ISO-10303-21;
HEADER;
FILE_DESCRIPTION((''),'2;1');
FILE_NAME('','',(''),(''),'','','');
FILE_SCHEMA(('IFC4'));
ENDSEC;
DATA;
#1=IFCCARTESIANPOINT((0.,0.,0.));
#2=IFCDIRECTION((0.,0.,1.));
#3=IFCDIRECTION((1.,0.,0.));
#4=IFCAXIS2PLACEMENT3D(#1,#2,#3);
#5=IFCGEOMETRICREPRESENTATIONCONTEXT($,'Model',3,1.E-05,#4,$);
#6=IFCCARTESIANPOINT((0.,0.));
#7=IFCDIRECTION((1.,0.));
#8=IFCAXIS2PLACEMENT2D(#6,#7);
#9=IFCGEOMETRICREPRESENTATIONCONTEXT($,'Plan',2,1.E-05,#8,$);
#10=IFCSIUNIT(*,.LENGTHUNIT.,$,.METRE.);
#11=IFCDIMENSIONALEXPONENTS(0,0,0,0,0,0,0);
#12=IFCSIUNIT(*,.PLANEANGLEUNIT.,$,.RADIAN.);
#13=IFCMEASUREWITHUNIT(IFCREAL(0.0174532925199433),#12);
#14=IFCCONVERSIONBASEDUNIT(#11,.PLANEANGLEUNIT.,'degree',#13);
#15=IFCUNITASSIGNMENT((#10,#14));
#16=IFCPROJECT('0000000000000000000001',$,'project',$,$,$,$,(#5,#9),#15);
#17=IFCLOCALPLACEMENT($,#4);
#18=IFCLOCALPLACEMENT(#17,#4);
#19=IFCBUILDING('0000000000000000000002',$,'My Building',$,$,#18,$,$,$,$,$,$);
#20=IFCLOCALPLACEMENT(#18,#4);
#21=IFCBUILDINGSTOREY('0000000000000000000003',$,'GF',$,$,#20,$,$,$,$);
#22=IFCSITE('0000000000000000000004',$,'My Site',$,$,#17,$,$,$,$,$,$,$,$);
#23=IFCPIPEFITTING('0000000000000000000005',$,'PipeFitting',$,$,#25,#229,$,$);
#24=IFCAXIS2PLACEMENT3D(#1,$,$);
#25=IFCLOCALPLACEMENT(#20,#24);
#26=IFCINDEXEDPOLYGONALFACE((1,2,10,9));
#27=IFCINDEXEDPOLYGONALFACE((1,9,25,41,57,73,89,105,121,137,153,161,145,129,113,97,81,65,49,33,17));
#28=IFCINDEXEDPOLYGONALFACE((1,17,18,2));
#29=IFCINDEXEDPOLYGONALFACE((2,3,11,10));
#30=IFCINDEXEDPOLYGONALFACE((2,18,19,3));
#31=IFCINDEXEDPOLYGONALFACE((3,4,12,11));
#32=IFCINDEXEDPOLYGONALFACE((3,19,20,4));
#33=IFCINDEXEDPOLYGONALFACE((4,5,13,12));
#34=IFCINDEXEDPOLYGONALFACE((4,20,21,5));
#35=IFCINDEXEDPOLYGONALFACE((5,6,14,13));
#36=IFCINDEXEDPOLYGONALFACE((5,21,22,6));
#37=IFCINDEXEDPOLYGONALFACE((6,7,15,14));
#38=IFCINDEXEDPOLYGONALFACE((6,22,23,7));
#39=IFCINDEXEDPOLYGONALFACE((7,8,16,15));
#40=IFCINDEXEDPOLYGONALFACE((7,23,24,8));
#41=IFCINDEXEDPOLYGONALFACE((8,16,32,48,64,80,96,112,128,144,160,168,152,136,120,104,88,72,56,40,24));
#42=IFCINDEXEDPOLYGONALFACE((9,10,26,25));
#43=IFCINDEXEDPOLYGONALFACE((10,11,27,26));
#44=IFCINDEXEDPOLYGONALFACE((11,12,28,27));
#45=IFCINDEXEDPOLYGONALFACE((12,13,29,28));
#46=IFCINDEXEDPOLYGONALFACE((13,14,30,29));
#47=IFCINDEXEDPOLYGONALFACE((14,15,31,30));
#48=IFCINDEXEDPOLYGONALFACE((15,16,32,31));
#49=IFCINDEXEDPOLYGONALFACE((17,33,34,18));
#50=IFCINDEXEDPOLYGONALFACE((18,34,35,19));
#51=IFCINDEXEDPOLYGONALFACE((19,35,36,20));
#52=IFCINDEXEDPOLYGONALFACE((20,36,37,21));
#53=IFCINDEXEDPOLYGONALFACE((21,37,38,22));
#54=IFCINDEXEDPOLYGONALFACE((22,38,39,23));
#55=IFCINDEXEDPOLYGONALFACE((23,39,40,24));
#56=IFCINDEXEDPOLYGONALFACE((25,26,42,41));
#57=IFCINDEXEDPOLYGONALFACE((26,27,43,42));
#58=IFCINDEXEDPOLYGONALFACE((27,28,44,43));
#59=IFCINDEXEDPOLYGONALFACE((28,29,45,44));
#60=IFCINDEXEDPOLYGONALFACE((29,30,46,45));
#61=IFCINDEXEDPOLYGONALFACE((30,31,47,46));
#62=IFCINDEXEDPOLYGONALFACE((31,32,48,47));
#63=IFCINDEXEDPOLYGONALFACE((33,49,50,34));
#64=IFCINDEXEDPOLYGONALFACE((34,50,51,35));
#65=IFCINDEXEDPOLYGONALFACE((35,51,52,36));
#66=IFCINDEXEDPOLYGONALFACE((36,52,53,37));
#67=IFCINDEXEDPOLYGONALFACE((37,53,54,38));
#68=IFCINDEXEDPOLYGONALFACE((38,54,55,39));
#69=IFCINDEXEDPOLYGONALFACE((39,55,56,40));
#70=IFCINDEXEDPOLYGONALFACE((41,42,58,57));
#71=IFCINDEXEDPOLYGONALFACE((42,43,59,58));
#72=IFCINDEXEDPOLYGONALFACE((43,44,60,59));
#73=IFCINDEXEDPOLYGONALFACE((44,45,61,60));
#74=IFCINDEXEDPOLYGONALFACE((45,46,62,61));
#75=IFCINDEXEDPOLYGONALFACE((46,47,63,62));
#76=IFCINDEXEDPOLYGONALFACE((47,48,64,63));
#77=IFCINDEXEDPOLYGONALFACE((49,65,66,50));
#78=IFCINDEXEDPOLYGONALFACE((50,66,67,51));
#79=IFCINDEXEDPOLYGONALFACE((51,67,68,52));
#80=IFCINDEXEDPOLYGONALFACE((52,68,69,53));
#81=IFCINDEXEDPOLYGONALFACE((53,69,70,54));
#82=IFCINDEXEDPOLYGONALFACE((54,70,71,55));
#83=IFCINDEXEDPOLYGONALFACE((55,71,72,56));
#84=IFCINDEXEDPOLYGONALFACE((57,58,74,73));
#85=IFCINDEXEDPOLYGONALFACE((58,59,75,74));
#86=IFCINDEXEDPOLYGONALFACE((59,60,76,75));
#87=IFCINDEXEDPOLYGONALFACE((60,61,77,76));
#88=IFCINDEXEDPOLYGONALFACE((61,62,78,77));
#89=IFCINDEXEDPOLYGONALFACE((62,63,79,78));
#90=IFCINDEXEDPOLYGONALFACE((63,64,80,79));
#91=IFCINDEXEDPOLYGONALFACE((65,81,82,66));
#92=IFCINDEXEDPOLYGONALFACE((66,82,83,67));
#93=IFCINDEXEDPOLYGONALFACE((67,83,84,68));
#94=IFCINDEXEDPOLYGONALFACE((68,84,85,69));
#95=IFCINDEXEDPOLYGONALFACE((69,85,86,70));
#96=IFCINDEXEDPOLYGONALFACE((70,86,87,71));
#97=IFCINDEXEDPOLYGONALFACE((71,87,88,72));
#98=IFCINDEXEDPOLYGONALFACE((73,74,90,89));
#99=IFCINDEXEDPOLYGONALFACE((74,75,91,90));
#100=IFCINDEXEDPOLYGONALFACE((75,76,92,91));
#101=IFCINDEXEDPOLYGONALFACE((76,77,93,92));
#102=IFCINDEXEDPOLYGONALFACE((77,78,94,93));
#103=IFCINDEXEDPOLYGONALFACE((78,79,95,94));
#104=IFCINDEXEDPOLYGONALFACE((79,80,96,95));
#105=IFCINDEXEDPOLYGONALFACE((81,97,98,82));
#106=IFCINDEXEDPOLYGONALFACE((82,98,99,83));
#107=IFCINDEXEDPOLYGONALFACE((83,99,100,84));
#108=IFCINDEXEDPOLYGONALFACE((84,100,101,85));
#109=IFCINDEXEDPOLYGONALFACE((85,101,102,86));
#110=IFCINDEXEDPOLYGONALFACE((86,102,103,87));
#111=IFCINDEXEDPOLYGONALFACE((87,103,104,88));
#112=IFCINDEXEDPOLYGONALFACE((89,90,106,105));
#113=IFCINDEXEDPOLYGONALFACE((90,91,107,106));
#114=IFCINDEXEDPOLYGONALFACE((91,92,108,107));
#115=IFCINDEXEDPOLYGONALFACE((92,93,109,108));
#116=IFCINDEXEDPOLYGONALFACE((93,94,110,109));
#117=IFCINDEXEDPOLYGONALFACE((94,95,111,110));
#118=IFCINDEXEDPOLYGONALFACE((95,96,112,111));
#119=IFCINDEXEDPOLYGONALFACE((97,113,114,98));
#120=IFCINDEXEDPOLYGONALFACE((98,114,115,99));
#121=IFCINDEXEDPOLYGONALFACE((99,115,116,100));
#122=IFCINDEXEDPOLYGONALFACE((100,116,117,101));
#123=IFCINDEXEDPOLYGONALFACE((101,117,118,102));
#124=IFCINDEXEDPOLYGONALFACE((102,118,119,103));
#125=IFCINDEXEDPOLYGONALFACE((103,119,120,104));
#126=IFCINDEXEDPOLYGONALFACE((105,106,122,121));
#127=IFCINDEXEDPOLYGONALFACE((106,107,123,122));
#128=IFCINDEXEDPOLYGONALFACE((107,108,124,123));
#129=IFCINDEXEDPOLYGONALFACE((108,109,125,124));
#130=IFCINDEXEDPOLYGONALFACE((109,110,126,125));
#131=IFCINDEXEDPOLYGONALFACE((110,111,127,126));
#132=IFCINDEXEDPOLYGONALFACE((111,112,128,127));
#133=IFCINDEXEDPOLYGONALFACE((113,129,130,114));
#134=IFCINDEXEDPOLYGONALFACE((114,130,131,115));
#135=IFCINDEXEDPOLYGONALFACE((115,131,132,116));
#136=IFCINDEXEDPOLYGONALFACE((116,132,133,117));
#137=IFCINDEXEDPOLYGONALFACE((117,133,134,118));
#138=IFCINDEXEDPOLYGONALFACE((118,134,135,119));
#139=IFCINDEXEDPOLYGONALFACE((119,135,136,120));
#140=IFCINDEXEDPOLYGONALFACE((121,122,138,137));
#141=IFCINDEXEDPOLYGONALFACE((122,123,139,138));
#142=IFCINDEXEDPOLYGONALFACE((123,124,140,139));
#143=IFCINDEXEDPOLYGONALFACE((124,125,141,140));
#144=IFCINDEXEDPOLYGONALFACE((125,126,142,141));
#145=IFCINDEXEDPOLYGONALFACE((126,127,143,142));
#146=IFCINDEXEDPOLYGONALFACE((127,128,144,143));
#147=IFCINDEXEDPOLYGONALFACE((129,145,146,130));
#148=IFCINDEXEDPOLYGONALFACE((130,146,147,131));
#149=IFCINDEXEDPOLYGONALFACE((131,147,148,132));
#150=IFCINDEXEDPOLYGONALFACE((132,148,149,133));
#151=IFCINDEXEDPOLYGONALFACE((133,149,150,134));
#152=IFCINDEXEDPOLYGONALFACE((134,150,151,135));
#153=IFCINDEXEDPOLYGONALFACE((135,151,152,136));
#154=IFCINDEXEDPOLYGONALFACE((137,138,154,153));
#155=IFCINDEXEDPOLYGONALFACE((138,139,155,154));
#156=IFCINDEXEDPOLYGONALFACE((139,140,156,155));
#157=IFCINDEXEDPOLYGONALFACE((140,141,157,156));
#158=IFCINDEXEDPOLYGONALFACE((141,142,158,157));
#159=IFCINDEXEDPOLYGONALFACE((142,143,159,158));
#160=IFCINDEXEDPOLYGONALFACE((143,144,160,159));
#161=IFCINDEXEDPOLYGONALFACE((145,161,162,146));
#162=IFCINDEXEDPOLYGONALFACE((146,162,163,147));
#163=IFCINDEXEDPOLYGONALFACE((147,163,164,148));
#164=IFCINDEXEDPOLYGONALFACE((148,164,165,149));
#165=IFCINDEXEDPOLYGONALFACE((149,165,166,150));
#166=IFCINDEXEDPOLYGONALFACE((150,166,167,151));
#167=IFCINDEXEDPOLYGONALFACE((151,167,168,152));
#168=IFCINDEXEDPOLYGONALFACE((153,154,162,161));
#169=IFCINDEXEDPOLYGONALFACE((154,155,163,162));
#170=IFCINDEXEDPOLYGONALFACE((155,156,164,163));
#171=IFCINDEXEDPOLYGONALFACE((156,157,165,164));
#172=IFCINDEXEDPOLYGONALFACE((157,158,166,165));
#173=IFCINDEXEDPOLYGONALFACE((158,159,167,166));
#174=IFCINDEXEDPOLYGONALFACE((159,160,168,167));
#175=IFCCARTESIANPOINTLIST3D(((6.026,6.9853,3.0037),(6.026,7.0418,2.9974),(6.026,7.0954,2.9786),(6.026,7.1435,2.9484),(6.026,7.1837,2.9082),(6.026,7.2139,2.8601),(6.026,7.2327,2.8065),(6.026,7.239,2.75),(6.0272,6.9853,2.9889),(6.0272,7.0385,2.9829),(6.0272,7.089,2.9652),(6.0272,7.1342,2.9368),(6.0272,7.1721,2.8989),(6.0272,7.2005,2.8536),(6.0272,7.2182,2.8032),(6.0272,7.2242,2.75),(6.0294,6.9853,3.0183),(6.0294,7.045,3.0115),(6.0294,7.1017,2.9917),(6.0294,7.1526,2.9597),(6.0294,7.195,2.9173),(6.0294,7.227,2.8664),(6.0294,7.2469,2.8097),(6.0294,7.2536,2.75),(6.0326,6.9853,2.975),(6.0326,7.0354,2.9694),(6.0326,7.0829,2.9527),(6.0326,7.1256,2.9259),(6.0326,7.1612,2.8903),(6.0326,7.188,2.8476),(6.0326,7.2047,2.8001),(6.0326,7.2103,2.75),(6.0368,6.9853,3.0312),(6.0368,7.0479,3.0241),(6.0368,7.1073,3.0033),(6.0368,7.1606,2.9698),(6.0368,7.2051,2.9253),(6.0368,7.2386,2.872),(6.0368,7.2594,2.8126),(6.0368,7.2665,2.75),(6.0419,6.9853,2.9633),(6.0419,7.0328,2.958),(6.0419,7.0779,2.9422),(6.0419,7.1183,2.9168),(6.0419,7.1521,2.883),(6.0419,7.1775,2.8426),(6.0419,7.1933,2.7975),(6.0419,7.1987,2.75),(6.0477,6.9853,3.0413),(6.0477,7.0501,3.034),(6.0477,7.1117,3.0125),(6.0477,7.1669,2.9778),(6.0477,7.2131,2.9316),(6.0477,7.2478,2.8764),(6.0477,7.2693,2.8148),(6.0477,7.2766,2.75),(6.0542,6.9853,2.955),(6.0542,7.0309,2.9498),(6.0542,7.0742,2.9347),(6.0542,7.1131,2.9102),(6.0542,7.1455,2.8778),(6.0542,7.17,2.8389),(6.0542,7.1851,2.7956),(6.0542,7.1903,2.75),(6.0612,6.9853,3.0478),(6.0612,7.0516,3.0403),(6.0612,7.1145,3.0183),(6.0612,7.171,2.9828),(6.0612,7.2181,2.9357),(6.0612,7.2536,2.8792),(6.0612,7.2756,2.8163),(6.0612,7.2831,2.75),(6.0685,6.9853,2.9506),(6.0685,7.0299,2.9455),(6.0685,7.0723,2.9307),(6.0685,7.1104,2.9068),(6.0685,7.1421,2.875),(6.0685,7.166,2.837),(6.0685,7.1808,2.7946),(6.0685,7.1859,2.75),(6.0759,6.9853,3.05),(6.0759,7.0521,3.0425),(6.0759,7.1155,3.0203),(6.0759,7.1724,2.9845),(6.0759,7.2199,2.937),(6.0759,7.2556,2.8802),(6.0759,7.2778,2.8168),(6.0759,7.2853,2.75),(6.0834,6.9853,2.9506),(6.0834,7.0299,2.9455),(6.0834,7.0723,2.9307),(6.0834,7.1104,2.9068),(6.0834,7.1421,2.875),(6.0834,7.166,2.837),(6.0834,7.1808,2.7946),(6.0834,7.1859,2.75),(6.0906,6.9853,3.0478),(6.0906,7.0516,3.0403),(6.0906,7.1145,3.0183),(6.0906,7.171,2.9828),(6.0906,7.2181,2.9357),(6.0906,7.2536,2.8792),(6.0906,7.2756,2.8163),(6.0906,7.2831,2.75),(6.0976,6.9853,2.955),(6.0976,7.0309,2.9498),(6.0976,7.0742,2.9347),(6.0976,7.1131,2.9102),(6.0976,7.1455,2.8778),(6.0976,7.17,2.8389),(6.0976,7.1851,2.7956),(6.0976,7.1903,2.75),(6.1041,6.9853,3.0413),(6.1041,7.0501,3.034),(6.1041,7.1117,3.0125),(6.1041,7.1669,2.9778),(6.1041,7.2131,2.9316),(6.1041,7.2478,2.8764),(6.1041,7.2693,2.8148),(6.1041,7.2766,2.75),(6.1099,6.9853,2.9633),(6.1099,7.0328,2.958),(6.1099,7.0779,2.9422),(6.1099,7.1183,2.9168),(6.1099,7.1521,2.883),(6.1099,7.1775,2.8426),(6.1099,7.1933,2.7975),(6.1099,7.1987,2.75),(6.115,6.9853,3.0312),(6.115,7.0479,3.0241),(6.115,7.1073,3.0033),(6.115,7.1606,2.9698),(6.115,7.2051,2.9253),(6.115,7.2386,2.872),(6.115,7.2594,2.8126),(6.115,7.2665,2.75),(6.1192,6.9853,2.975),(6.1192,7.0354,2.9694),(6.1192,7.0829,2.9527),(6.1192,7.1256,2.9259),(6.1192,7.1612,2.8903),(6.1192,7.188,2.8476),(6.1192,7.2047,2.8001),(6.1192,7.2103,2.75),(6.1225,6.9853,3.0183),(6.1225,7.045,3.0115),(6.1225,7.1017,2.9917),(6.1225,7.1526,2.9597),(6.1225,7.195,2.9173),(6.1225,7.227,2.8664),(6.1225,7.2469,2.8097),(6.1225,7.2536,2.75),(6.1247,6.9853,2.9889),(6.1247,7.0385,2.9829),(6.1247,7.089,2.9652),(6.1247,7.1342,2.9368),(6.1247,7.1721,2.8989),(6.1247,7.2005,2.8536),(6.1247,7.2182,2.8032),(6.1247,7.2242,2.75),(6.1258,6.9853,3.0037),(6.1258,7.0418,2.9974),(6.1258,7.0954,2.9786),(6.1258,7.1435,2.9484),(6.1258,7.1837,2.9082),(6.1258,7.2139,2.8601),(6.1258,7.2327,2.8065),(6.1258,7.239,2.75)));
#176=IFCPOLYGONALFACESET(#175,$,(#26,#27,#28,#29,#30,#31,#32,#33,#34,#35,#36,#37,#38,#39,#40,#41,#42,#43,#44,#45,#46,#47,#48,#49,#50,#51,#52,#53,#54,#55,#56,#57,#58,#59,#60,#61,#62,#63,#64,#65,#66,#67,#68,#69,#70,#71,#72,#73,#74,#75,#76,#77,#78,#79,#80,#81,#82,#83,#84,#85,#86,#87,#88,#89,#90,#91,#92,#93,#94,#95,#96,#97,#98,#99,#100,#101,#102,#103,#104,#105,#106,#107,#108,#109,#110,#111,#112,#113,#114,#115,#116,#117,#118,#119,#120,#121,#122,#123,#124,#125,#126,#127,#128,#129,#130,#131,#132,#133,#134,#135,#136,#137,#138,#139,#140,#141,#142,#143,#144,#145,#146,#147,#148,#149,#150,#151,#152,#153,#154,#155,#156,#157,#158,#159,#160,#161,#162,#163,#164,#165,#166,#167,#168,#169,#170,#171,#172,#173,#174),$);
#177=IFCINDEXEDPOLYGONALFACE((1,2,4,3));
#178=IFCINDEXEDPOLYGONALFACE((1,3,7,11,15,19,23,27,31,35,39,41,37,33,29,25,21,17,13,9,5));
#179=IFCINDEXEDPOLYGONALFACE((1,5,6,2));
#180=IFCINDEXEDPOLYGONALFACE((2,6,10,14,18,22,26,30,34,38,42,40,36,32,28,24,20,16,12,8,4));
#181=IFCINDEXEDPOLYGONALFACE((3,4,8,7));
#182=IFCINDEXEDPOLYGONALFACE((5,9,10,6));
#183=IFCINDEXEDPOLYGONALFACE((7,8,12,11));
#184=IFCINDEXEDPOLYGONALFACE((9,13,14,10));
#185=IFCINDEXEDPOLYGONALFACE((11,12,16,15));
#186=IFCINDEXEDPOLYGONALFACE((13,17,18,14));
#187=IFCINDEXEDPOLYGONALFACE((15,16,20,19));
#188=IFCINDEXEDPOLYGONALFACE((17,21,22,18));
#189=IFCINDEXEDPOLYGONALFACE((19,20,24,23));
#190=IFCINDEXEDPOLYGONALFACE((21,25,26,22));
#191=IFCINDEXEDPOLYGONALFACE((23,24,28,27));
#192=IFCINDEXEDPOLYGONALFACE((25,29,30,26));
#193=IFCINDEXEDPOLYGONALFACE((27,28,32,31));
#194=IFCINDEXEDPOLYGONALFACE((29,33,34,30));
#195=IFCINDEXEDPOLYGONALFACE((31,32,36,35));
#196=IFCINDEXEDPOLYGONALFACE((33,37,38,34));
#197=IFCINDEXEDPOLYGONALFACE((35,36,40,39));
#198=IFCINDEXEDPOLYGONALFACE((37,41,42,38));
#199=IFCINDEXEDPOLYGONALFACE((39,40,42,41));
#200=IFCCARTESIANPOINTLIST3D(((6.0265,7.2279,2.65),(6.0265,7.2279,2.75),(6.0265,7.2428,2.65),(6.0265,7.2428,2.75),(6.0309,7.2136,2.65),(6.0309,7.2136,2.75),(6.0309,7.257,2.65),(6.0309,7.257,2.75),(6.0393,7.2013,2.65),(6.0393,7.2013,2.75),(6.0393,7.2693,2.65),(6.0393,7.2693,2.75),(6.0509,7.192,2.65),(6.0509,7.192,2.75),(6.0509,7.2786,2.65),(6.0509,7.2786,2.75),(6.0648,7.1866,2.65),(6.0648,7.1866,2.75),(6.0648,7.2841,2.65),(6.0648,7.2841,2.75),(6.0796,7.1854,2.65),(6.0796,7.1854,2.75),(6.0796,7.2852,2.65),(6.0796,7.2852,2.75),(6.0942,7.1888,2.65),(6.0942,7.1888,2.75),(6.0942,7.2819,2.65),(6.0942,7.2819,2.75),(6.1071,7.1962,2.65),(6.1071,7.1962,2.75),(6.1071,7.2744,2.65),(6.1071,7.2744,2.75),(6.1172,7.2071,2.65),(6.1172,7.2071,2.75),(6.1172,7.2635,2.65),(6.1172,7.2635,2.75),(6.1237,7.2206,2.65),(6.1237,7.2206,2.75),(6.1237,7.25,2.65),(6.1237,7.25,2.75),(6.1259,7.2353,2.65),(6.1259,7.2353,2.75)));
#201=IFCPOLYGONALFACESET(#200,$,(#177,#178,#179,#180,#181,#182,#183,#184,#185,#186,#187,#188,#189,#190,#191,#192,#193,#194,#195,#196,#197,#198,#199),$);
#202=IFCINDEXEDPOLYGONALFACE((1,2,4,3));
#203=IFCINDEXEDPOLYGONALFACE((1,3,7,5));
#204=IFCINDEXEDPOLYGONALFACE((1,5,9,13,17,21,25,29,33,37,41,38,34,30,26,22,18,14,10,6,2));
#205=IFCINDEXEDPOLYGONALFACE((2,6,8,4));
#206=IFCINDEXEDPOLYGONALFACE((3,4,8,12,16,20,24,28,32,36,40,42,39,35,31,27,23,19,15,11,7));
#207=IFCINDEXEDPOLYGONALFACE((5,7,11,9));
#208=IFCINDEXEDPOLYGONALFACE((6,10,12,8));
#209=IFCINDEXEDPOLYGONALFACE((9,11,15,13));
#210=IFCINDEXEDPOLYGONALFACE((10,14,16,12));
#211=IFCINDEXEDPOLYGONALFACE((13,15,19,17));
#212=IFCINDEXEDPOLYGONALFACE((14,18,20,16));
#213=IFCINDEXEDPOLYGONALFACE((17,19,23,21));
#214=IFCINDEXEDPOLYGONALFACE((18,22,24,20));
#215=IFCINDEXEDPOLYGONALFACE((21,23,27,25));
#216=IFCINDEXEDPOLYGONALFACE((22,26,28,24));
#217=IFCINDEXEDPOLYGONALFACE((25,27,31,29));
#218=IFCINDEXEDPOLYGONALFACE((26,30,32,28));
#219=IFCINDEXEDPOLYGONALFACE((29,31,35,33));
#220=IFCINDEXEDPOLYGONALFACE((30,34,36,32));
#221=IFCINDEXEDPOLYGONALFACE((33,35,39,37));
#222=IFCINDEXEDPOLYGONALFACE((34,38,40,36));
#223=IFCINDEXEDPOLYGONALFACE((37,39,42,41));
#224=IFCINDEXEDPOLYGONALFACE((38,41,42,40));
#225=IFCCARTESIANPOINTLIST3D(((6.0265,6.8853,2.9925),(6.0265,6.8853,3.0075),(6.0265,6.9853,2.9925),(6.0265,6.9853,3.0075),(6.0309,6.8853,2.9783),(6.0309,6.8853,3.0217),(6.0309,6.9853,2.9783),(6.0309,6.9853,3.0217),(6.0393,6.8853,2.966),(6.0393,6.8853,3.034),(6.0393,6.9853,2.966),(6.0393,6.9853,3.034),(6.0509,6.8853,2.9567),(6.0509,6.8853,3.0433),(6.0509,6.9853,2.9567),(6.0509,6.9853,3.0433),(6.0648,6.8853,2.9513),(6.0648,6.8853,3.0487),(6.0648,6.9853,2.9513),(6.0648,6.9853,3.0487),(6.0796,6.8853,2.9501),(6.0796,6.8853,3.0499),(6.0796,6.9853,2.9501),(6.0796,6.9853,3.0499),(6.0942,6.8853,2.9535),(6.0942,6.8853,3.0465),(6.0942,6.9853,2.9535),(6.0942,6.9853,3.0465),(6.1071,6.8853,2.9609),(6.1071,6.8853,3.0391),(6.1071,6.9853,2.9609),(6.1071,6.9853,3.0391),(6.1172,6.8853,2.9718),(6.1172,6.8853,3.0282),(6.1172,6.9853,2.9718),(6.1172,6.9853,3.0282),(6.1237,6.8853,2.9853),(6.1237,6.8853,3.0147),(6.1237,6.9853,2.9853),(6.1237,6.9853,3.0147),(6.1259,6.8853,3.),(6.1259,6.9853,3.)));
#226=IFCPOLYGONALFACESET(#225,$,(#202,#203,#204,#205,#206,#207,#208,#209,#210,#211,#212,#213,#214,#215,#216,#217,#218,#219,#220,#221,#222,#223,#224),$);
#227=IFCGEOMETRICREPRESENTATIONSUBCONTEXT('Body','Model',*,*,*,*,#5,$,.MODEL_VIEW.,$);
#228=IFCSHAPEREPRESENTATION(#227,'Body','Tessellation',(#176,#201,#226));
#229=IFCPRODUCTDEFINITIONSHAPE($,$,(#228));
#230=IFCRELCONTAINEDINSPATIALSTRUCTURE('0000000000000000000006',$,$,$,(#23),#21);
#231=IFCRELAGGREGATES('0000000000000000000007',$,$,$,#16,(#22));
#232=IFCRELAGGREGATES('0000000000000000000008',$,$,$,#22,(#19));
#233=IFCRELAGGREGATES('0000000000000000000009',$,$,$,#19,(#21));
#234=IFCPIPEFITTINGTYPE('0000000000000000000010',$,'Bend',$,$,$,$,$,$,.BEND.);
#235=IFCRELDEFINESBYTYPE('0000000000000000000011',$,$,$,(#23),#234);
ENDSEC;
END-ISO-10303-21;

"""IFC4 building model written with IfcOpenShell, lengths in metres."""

from ifc_helpers import new_model, entity, si_unit, converted_unit, frame, origin_with_axes, origin_2d_with_axis, place, context, subcontext, project, spatial, circle, extrude, source, transform, mapped, type_object, type_shapes, element, save


model = new_model("IFC4")

# Units and contexts
model_context = context("Model", 3, precision=1e-05, world=origin_with_axes())
plan_context = context("Plan", 2, precision=1e-05, world=origin_2d_with_axis())
body_context = subcontext(model_context, "Body", "Model", "MODEL_VIEW")
ifc_project = project(units=[si_unit("LENGTHUNIT", "METRE"), converted_unit("PLANEANGLEUNIT", "degree", entity("IfcReal", 0.0174532925199433), si_unit("PLANEANGLEUNIT", "RADIAN"), dimensions=[0, 0, 0, 0, 0, 0, 0])], contexts=[model_context, plan_context])

# Site, building, storey
site_placement = place(None, origin_with_axes())
site = spatial("IfcSite", under=ifc_project, at=site_placement, Name="My Site")
building_placement = place(site_placement, origin_with_axes())
building = spatial("IfcBuilding", under=site, at=building_placement, Name="My Building")
storey_placement = place(building_placement, origin_with_axes())
storey = spatial("IfcBuildingStorey", under=building, at=storey_placement, Name="GF")

# Pipe fitting
pipe_fitting_type = type_object("IfcPipeFittingType", Name="Bend", PredefinedType="BEND")
shared_shape = source(origin_with_axes(), body_context, "Body", "SolidModel", [
    entity("IfcSweptDiskSolid", entity("IfcIndexedPolyCurve", entity("IfcCartesianPointList3D", [[0.0, 0.0, -0.1], [0.0, 0.0732, -0.2768], [0.0, 0.25, -0.35]]), [entity("IfcArcIndex", [1, 2, 3])]), 0.05),
    extrude(circle(Radius=0.05), origin_with_axes(), (0.0, 0.0, -1.0), 0.1),
    extrude(circle(Radius=0.05), frame((0.0, 0.25, -0.35), z_axis=(0.0, 1.0, 0.0), x_axis=(1.0, 0.0, 0.0)), (0.0, 0.0, 1.0), 0.1),
])
type_shapes(pipe_fitting_type, [shared_shape])
for number, where, z_axis, x_axis, name in (
    (1, (6.0759, 7.2353, 2.65), (0.0, 0.0, -1.0), (1.0, 0.0, 0.0), "PipeFitting"),
):
    element("IfcPipeFitting", number, at=place(storey_placement, frame(where, z_axis=z_axis, x_axis=x_axis)), inside=storey, type_object=pipe_fitting_type, Name=name, context=body_context, shape_type="MappedRepresentation", body=[
        mapped(shared_shape, transform((0.0, 0.0, 0.0), x_axis=(1.0, 0.0, 0.0), y_axis=(0.0, 1.0, 0.0), z_axis=(0.0, 0.0, 1.0), scale=1.0)),
    ])

save(model, "model.ifc")
